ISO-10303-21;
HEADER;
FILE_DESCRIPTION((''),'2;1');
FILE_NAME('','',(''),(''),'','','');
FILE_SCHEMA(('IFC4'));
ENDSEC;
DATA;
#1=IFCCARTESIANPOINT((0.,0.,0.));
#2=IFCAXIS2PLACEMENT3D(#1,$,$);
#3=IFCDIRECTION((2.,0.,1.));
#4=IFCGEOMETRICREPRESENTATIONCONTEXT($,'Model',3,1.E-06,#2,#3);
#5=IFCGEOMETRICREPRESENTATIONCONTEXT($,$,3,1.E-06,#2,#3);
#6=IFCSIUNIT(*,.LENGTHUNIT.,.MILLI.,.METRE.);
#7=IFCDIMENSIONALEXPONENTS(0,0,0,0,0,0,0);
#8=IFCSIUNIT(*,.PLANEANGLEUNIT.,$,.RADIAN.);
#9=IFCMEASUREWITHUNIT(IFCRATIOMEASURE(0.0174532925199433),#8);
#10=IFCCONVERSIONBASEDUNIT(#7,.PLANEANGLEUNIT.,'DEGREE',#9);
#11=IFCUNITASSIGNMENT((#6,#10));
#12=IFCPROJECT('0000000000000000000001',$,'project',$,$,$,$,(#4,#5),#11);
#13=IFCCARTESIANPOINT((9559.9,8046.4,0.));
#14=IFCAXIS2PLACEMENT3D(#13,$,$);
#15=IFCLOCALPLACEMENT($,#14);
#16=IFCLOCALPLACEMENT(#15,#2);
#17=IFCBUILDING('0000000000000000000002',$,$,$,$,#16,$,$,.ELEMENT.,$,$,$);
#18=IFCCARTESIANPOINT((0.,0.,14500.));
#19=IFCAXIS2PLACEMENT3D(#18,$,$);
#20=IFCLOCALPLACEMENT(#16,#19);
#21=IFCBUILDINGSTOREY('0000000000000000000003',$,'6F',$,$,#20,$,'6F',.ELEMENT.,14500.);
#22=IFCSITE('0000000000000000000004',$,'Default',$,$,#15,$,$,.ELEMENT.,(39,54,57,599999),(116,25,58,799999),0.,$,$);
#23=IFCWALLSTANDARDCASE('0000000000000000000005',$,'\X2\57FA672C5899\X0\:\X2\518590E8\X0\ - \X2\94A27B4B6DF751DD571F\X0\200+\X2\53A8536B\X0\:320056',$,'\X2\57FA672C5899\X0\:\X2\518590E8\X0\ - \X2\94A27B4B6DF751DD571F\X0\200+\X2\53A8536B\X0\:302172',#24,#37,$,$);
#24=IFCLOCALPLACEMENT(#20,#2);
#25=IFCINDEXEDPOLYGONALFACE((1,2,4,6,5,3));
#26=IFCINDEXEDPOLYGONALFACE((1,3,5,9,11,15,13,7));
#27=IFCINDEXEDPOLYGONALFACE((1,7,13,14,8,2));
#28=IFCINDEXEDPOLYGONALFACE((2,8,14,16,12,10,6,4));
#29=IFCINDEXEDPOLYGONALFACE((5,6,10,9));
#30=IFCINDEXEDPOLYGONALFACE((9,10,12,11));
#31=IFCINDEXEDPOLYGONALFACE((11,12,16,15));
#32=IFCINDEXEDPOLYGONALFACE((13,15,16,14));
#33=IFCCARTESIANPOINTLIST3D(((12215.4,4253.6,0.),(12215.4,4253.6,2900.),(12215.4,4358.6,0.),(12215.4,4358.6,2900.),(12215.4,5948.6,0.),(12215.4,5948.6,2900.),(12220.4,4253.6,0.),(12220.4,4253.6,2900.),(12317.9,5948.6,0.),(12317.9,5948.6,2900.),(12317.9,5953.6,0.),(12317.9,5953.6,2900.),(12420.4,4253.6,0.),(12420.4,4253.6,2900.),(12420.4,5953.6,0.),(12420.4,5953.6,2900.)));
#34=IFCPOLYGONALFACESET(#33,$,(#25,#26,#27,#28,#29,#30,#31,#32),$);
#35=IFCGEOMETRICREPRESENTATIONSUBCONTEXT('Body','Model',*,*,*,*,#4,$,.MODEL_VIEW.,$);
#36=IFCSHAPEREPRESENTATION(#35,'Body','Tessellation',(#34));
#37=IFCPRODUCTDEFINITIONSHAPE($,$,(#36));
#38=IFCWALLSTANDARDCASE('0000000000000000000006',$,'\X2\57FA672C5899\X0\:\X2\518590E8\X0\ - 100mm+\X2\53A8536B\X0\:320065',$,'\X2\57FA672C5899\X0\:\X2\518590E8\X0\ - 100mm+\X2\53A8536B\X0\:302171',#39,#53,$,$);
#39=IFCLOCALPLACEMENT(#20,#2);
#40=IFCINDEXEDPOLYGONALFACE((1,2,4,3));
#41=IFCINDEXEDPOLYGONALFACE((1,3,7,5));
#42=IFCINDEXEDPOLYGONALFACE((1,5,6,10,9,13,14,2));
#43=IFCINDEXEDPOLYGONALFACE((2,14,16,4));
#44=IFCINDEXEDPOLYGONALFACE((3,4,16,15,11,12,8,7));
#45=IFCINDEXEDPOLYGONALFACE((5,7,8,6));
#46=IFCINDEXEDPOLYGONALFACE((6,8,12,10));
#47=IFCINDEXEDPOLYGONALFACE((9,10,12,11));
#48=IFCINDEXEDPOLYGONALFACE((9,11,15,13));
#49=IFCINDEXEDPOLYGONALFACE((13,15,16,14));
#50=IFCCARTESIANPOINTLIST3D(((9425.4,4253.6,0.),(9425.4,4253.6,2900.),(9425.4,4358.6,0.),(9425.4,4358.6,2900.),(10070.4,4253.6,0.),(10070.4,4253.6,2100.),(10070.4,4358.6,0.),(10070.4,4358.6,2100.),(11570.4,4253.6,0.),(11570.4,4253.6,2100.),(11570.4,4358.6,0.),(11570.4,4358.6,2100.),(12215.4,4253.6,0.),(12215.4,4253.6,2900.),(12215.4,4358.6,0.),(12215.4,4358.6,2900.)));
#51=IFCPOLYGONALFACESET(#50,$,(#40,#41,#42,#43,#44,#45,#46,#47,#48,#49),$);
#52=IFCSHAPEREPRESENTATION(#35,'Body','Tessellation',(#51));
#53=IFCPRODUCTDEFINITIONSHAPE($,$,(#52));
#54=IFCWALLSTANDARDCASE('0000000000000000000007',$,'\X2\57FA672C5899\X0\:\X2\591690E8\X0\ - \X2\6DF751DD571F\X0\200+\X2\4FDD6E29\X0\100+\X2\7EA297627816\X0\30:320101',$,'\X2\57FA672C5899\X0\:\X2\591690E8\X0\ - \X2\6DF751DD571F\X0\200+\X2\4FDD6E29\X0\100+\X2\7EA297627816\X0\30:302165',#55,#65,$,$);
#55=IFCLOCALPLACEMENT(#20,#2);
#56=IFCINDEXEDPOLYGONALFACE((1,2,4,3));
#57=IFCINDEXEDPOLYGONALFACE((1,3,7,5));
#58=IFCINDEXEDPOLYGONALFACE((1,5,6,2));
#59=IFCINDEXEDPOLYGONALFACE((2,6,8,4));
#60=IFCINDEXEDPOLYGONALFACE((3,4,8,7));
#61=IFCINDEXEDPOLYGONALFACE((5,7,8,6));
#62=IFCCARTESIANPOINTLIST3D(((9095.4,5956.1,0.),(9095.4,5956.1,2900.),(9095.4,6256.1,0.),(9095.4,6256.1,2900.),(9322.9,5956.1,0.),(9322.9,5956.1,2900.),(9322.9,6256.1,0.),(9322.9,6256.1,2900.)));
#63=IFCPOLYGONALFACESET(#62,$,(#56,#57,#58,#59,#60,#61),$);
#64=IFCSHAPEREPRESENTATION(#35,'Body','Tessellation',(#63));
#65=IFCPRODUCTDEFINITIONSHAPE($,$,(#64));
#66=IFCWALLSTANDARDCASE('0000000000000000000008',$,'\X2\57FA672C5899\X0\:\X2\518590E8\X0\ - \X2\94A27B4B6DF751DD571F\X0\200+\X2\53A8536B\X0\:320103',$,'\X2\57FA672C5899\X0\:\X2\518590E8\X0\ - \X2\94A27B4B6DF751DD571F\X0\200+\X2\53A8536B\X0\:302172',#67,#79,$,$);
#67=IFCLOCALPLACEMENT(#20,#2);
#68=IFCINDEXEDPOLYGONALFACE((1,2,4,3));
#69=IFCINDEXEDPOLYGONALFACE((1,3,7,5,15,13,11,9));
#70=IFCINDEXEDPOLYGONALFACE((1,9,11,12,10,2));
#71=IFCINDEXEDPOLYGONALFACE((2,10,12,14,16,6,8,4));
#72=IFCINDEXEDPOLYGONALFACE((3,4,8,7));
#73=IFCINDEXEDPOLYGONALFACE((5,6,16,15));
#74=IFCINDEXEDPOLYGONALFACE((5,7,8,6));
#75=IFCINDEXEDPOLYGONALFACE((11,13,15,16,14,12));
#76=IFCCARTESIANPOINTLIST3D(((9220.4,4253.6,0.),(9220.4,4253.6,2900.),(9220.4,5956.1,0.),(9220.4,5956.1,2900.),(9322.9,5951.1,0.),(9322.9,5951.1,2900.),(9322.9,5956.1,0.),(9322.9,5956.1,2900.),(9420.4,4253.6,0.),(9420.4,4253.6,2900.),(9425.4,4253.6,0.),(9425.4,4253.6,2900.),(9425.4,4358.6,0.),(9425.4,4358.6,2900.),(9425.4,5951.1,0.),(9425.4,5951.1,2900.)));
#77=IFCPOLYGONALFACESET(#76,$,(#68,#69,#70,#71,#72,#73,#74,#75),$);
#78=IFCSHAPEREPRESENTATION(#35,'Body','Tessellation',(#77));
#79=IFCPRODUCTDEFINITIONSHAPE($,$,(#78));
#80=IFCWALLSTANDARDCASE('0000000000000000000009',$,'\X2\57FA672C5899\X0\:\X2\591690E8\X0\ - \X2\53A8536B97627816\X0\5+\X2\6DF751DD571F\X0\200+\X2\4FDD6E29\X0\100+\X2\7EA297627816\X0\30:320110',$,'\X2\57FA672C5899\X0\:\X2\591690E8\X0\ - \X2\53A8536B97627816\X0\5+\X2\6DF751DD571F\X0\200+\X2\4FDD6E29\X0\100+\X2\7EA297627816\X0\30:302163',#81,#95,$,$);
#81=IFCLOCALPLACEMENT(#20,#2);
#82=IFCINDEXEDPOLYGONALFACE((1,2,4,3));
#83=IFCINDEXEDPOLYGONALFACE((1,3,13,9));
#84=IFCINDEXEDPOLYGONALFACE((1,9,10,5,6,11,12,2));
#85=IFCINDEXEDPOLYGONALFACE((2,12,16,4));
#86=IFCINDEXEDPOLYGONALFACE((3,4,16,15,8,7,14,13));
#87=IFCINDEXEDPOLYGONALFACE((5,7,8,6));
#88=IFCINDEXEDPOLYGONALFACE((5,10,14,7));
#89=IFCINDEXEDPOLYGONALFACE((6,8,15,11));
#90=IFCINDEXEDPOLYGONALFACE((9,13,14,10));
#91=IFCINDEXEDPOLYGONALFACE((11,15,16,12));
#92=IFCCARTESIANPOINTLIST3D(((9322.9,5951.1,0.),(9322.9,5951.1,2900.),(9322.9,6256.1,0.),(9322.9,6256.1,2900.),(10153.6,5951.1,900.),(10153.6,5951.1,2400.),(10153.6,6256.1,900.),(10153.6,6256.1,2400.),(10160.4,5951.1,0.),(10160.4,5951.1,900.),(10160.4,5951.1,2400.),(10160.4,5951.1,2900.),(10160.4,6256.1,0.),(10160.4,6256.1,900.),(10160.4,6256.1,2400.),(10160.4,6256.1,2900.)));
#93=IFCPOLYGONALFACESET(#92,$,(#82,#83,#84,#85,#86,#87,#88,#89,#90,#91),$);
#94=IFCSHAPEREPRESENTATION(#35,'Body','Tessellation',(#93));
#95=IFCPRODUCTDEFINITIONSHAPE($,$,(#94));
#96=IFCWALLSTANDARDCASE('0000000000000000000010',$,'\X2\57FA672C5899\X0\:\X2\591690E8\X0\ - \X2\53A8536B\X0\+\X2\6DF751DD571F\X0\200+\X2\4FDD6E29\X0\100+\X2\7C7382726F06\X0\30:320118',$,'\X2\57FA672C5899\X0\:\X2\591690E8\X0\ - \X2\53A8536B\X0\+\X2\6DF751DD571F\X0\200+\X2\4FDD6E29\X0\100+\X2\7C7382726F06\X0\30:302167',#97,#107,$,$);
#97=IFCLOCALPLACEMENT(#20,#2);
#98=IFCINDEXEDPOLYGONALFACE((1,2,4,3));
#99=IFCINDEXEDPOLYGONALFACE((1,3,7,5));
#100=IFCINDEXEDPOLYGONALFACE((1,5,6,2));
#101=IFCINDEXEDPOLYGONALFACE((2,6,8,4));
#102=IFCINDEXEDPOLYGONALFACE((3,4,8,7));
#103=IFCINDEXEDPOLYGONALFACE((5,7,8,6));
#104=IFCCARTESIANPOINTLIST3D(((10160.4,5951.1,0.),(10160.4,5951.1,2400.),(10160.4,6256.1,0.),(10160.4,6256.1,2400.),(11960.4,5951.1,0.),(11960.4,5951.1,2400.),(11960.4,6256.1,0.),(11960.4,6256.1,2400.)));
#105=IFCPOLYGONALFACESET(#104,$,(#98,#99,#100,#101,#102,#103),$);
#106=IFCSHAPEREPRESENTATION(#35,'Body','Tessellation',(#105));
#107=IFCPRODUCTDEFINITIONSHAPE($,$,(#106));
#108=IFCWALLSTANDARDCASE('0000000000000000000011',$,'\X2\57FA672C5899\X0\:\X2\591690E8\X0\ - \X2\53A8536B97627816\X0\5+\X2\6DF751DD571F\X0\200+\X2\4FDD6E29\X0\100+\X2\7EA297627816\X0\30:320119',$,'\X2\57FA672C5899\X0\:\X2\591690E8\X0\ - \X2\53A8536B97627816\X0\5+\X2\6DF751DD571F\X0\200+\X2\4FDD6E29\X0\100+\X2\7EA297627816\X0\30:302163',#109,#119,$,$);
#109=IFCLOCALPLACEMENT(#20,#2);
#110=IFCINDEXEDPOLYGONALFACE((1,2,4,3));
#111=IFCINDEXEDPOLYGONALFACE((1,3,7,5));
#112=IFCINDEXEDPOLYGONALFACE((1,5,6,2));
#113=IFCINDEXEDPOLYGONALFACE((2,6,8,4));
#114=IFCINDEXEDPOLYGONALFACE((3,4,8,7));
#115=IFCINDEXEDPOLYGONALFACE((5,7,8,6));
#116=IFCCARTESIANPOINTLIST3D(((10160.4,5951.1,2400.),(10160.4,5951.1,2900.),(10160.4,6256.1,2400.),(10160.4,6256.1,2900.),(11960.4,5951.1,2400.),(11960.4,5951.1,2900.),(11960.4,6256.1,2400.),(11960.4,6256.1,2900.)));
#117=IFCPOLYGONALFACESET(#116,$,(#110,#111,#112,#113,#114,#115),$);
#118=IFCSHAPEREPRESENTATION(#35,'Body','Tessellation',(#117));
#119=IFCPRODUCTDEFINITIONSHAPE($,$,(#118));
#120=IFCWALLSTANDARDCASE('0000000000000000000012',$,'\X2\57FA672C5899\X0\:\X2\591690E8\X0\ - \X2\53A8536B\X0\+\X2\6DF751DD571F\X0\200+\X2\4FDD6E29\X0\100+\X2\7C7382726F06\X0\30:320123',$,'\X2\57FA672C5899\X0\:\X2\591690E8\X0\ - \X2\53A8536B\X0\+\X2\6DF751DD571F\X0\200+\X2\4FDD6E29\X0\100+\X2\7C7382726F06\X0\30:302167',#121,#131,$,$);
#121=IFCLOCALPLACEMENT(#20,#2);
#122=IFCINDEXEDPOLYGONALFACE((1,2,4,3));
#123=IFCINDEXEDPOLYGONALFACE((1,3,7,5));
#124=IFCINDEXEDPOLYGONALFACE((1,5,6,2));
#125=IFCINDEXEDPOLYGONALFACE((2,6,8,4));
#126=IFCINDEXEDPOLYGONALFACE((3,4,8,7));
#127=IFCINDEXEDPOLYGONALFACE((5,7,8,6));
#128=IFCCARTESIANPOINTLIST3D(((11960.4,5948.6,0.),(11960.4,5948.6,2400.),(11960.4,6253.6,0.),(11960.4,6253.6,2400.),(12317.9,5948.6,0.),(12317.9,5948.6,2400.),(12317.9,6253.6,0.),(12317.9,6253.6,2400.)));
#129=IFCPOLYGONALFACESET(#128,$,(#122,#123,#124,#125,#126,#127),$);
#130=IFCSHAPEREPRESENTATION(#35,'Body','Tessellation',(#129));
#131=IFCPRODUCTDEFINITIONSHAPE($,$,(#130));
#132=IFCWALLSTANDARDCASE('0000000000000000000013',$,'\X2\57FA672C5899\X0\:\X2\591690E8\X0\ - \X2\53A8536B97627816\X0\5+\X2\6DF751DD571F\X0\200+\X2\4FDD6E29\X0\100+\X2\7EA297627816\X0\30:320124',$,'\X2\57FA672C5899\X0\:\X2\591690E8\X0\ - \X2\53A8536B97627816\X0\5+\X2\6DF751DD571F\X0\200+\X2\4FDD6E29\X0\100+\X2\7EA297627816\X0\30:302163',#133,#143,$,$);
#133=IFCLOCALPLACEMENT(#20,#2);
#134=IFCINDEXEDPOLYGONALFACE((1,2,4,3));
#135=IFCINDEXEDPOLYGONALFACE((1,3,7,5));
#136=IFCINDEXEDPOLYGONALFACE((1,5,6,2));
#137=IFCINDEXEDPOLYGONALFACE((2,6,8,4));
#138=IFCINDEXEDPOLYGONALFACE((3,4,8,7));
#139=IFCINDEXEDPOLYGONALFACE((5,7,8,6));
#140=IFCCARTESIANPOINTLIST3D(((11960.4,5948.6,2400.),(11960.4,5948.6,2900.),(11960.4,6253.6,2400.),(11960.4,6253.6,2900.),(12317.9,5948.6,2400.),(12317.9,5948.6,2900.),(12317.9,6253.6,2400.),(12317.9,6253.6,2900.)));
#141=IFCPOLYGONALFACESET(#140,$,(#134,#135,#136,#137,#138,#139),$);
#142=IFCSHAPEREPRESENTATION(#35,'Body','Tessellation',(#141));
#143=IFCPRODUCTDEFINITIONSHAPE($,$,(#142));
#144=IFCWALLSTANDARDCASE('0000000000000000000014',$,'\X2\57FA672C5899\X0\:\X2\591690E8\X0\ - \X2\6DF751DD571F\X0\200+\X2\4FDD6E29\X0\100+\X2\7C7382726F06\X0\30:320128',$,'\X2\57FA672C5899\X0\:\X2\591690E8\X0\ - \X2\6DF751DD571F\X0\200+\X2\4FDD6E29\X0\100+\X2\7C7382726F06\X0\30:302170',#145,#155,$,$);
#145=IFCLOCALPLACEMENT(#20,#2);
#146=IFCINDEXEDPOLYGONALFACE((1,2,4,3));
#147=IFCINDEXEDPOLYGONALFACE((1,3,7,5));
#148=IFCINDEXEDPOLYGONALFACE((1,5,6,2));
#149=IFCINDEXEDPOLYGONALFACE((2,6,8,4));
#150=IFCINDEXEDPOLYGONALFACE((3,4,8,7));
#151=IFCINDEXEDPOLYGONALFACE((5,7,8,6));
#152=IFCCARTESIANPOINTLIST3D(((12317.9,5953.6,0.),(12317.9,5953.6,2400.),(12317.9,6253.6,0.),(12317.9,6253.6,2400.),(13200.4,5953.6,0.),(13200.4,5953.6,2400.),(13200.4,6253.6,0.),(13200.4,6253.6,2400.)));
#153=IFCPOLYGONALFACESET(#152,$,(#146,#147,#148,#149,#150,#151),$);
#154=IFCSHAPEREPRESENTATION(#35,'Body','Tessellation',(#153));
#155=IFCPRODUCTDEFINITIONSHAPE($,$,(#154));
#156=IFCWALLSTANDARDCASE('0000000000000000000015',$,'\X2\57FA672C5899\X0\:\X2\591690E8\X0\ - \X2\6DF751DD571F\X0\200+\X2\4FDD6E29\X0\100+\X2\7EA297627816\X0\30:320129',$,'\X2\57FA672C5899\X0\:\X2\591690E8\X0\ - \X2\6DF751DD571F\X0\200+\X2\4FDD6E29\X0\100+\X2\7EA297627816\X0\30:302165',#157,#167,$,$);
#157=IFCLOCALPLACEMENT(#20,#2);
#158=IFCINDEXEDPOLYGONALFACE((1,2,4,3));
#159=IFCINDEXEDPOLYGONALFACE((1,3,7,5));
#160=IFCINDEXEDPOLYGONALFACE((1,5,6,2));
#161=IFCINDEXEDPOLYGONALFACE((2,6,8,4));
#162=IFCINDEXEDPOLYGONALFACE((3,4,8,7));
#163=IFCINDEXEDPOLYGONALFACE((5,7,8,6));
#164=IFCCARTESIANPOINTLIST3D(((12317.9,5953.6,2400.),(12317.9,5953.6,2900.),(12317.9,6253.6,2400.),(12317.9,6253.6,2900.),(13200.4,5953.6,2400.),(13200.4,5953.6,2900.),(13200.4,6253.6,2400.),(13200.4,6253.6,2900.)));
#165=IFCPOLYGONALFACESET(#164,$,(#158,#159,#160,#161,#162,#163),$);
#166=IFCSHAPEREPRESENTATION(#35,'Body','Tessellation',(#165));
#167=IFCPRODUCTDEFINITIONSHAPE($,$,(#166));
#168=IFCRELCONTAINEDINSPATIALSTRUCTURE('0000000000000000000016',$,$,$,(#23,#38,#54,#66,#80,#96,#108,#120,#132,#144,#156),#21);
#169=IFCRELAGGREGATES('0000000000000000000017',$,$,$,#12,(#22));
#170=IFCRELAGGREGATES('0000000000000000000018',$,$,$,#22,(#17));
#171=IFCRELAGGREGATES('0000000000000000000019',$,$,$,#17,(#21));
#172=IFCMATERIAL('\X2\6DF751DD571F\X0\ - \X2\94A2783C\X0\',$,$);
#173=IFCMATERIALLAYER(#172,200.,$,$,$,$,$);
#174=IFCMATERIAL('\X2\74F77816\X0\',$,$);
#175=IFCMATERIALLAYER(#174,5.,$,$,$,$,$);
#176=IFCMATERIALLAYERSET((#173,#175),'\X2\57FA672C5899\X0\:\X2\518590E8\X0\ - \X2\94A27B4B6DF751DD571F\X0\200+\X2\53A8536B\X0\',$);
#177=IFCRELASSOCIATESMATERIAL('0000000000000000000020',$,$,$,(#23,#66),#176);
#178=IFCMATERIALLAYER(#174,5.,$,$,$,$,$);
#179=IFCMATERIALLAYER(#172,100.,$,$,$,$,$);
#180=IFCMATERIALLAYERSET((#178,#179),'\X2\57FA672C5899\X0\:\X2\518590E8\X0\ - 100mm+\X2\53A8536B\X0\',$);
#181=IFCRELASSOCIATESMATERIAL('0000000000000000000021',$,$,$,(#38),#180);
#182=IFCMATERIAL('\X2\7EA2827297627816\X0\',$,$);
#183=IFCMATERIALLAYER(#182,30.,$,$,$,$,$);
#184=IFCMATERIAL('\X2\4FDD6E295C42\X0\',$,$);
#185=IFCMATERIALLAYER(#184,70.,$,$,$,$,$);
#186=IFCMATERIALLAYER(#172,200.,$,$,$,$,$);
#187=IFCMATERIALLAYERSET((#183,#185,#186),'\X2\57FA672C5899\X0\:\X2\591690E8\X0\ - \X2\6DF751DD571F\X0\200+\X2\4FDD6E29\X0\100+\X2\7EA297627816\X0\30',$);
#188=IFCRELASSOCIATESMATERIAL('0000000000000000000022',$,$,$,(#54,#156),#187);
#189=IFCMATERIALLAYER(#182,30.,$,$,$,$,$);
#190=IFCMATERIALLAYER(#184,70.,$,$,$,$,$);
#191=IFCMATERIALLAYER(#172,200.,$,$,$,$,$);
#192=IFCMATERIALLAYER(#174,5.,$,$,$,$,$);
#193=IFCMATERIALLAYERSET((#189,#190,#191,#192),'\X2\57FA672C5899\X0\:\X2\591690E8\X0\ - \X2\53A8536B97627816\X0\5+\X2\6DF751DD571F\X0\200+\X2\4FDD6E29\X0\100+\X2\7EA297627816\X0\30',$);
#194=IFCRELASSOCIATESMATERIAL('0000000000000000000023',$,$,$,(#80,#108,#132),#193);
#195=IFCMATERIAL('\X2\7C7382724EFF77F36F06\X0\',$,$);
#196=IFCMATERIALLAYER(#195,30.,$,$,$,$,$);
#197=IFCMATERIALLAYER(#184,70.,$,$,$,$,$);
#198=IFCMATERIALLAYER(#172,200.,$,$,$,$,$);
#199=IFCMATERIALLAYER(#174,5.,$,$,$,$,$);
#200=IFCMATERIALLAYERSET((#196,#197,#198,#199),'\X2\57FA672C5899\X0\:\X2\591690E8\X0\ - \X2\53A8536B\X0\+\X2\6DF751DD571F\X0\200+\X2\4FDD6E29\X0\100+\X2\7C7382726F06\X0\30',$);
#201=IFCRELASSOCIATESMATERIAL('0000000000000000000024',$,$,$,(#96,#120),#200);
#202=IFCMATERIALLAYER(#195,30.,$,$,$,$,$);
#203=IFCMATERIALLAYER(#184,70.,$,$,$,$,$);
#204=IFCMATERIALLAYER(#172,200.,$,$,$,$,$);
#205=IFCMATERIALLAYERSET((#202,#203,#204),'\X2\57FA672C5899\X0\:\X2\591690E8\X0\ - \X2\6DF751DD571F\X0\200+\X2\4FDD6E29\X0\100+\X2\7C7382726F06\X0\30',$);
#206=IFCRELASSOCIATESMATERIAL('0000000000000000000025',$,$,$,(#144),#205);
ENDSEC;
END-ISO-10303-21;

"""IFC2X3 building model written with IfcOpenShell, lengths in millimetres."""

from ifc_helpers import new_model, entity, si_unit, converted_unit, direction, frame, frame_2d, origin, place, context, subcontext, project, spatial, polyline, rectangle, outline, extrude, material, layer, layer_set, layer_usage, element, save


model = new_model("IFC2X3")

# Units and contexts
model_context = context("Model", 3, precision=1e-06, world=origin(), true_north=direction((2.0, 0.0, 1.0)))
context_of_model = context(None, 3, precision=1e-06, world=origin(), true_north=direction((2.0, 0.0, 1.0)))
body_context = subcontext(model_context, "Body", "Model", "MODEL_VIEW")
ifc_project = project(units=[si_unit("LENGTHUNIT", "METRE", prefix="MILLI"), converted_unit("PLANEANGLEUNIT", "DEGREE", entity("IfcRatioMeasure", 0.0174532925199433), si_unit("PLANEANGLEUNIT", "RADIAN"), dimensions=[0, 0, 0, 0, 0, 0, 0])], contexts=[model_context, context_of_model])

# Site, building, storey
site_placement = place(None, frame((9559.9, 8046.4, 0.0)))
site = spatial("IfcSite", under=ifc_project, at=site_placement, Name="Default", CompositionType="ELEMENT", RefLatitude=(39, 54, 57, 599999), RefLongitude=(116, 25, 58, 799999), RefElevation=0.0)
building_placement = place(site_placement, origin())
building = spatial("IfcBuilding", under=site, at=building_placement, CompositionType="ELEMENT")
storey_placement = place(building_placement, frame((0.0, 0.0, 14500.0)))
storey = spatial("IfcBuildingStorey", under=building, at=storey_placement, Name="6F", LongName="6F", CompositionType="ELEMENT", Elevation=14500.0)

# Shared definitions
ifc_material_1 = material(Name="红色面砖")
ifc_layer_1 = layer(ifc_material_1, 30.0)
ifc_material_2 = material(Name="保温层")
ifc_layer_2 = layer(ifc_material_2, 70.0)
ifc_material_3 = material(Name="混凝土 - 钢砼")
ifc_layer_3 = layer(ifc_material_3, 200.0)
ifc_layer_set_1 = layer_set([ifc_layer_1, ifc_layer_2, ifc_layer_3], Name="基本墙:外部 - 混凝土200+保温100+红面砖30")

# Wall
ifc_layer_4 = layer(ifc_material_3, 200.0)
ifc_material_4 = material(Name="瓷砖")
ifc_layer_5 = layer(ifc_material_4, 5.0)
ifc_layer_set_2 = layer_set([ifc_layer_4, ifc_layer_5], Name="基本墙:内部 - 钢筋混凝土200+厨卫")
ifc_layer_usage_1 = layer_usage(ifc_layer_set_2, "AXIS2", "NEGATIVE", 102.5)
wall_1_placement = place(storey_placement, frame((12317.9, 5953.6, 0.0), z_axis=(0.0, 0.0, 1.0), x_axis=(0.0, -1.0, 0.0)))
element("IfcWallStandardCase", 1, at=wall_1_placement, inside=storey, material=ifc_layer_usage_1, Name="基本墙:内部 - 钢筋混凝土200+厨卫:320056", ObjectType="基本墙:内部 - 钢筋混凝土200+厨卫:302172", context=body_context, shape_type="SweptSolid", body=[
    extrude(outline(polyline([(1700.0, -102.5), (1700.0, -97.5), (1700.0, 102.5), (0.0, 102.5), (0.0, 0.0), (5.0, 0.0), (5.0, -102.5), (1595.0, -102.5), (1700.0, -102.5)])), origin(), (0.0, 0.0, 1.0), 2900.0),
])

# Wall, opening
ifc_layer_6 = layer(ifc_material_4, 5.0)
ifc_layer_7 = layer(ifc_material_3, 100.0)
ifc_layer_set_3 = layer_set([ifc_layer_6, ifc_layer_7], Name="基本墙:内部 - 100mm+厨卫")
ifc_layer_usage_2 = layer_usage(ifc_layer_set_3, "AXIS2", "POSITIVE", -52.5)
wall_2_placement = place(storey_placement, frame((12215.4, 4306.1, 0.0), z_axis=(0.0, 0.0, 1.0), x_axis=(-1.0, 0.0, 0.0)))
wall_2 = element("IfcWallStandardCase", 2, at=wall_2_placement, inside=storey, material=ifc_layer_usage_2, Name="基本墙:内部 - 100mm+厨卫:320065", ObjectType="基本墙:内部 - 100mm+厨卫:302171", context=body_context, shape_type="SweptSolid", body=[
    extrude(rectangle(XDim=2790.0, YDim=105.0, at=frame_2d((1395.0, 0.0), x_axis=(-1.0, 0.0))), origin(), (0.0, 0.0, 1.0), 2900.0),
])
opening_1_placement = place(wall_2_placement, frame((645.0, -52.5, 0.0)))
element("IfcOpeningElement", 3, at=opening_1_placement, cuts=wall_2, ObjectType="Opening", context=body_context, shape_type="SweptSolid", body=[
    extrude(rectangle(XDim=2100.0, YDim=1500.0, at=frame_2d((1050.0, 750.0), x_axis=(1.0, 0.0))), frame((0.0, 0.0, 0.0), z_axis=(0.0, 1.0, 0.0), x_axis=(0.0, 0.0, 1.0)), (0.0, 0.0, 1.0), 105.0),
])

# Walls
ifc_layer_usage_3 = layer_usage(ifc_layer_set_1, "AXIS2", "POSITIVE", -150.0)
wall_3_placement = place(storey_placement, frame((9322.9, 6106.1, 0.0), z_axis=(0.0, 0.0, 1.0), x_axis=(-1.0, 0.0, 0.0)))
element("IfcWallStandardCase", 4, at=wall_3_placement, inside=storey, material=ifc_layer_usage_3, Name="基本墙:外部 - 混凝土200+保温100+红面砖30:320101", ObjectType="基本墙:外部 - 混凝土200+保温100+红面砖30:302165", context=body_context, shape_type="SweptSolid", body=[
    extrude(rectangle(XDim=227.5, YDim=300.0, at=frame_2d((113.8, 0.0), x_axis=(-1.0, 0.0))), origin(), (0.0, 0.0, 1.0), 2900.0),
])
ifc_layer_usage_4 = layer_usage(ifc_layer_set_2, "AXIS2", "POSITIVE", -102.5)
wall_4_placement = place(storey_placement, frame((9322.9, 5956.1, 0.0), z_axis=(0.0, 0.0, 1.0), x_axis=(0.0, -1.0, 0.0)))
element("IfcWallStandardCase", 5, at=wall_4_placement, inside=storey, material=ifc_layer_usage_4, Name="基本墙:内部 - 钢筋混凝土200+厨卫:320103", ObjectType="基本墙:内部 - 钢筋混凝土200+厨卫:302172", context=body_context, shape_type="SweptSolid", body=[
    extrude(outline(polyline([(1702.5, -102.5), (1702.5, 97.5), (1702.5, 102.5), (1597.5, 102.5), (5.0, 102.5), (5.0, 0.0), (0.0, 0.0), (0.0, -102.5), (1702.5, -102.5)])), origin(), (0.0, 0.0, 1.0), 2900.0),
])

# Wall, opening
ifc_layer_8 = layer(ifc_material_1, 30.0)
ifc_layer_9 = layer(ifc_material_2, 70.0)
ifc_layer_10 = layer(ifc_material_3, 200.0)
ifc_layer_11 = layer(ifc_material_4, 5.0)
ifc_layer_set_4 = layer_set([ifc_layer_8, ifc_layer_9, ifc_layer_10, ifc_layer_11], Name="基本墙:外部 - 厨卫面砖5+混凝土200+保温100+红面砖30")
ifc_layer_usage_5 = layer_usage(ifc_layer_set_4, "AXIS2", "POSITIVE", -152.5)
wall_5_placement = place(storey_placement, frame((10160.4, 6103.6, 0.0), z_axis=(0.0, 0.0, 1.0), x_axis=(-1.0, 0.0, 0.0)))
wall_5 = element("IfcWallStandardCase", 6, at=wall_5_placement, inside=storey, material=ifc_layer_usage_5, Name="基本墙:外部 - 厨卫面砖5+混凝土200+保温100+红面砖30:320110", ObjectType="基本墙:外部 - 厨卫面砖5+混凝土200+保温100+红面砖30:302163", context=body_context, shape_type="SweptSolid", body=[
    extrude(rectangle(XDim=837.5, YDim=305.0, at=frame_2d((418.8, 0.0), x_axis=(-1.0, 0.0))), origin(), (0.0, 0.0, 1.0), 2900.0),
])
opening_2_placement = place(wall_5_placement, frame((6.7, 152.5, 900.0)))
element("IfcOpeningElement", 7, at=opening_2_placement, cuts=wall_5, ObjectType="Opening", context=body_context, shape_type="SweptSolid", body=[
    extrude(rectangle(XDim=1500.0, YDim=1800.0, at=frame_2d((750.0, 900.0), x_axis=(1.0, 0.0))), frame((0.0, 0.0, 0.0), z_axis=(0.0, -1.0, 0.0), x_axis=(0.0, 0.0, 1.0)), (0.0, 0.0, 1.0), 305.0),
])

# Walls
ifc_material_5 = material(Name="米色仿石漆")
ifc_layer_12 = layer(ifc_material_5, 30.0)
ifc_layer_13 = layer(ifc_material_2, 70.0)
ifc_layer_14 = layer(ifc_material_3, 200.0)
ifc_layer_15 = layer(ifc_material_4, 5.0)
ifc_layer_set_5 = layer_set([ifc_layer_12, ifc_layer_13, ifc_layer_14, ifc_layer_15], Name="基本墙:外部 - 厨卫+混凝土200+保温100+米色漆30")
ifc_layer_usage_6 = layer_usage(ifc_layer_set_5, "AXIS2", "POSITIVE", -152.5)
wall_6_placement = place(storey_placement, frame((11960.4, 6103.6, 0.0), z_axis=(0.0, 0.0, 1.0), x_axis=(-1.0, 0.0, 0.0)))
element("IfcWallStandardCase", 8, at=wall_6_placement, inside=storey, material=ifc_layer_usage_6, Name="基本墙:外部 - 厨卫+混凝土200+保温100+米色漆30:320118", ObjectType="基本墙:外部 - 厨卫+混凝土200+保温100+米色漆30:302167", context=body_context, shape_type="SweptSolid", body=[
    extrude(rectangle(XDim=1800.0, YDim=305.0, at=frame_2d((900.0, 0.0), x_axis=(-1.0, 0.0))), origin(), (0.0, 0.0, 1.0), 2400.0),
])
ifc_layer_usage_7 = layer_usage(ifc_layer_set_4, "AXIS2", "POSITIVE", -152.5)
wall_7_placement = place(storey_placement, frame((11960.4, 6103.6, 2400.0), z_axis=(0.0, 0.0, 1.0), x_axis=(-1.0, 0.0, 0.0)))
element("IfcWallStandardCase", 9, at=wall_7_placement, inside=storey, material=ifc_layer_usage_7, Name="基本墙:外部 - 厨卫面砖5+混凝土200+保温100+红面砖30:320119", ObjectType="基本墙:外部 - 厨卫面砖5+混凝土200+保温100+红面砖30:302163", context=body_context, shape_type="SweptSolid", body=[
    extrude(rectangle(XDim=1800.0, YDim=305.0, at=frame_2d((900.0, 0.0), x_axis=(-1.0, 0.0))), origin(), (0.0, 0.0, 1.0), 500.0),
])
ifc_layer_usage_8 = layer_usage(ifc_layer_set_5, "AXIS2", "POSITIVE", -152.5)
wall_8_placement = place(storey_placement, frame((12317.9, 6101.1, 0.0), z_axis=(0.0, 0.0, 1.0), x_axis=(-1.0, 0.0, 0.0)))
element("IfcWallStandardCase", 10, at=wall_8_placement, inside=storey, material=ifc_layer_usage_8, Name="基本墙:外部 - 厨卫+混凝土200+保温100+米色漆30:320123", ObjectType="基本墙:外部 - 厨卫+混凝土200+保温100+米色漆30:302167", context=body_context, shape_type="SweptSolid", body=[
    extrude(rectangle(XDim=357.5, YDim=305.0, at=frame_2d((178.8, 0.0), x_axis=(-1.0, 0.0))), origin(), (0.0, 0.0, 1.0), 2400.0),
])
ifc_layer_usage_9 = layer_usage(ifc_layer_set_4, "AXIS2", "POSITIVE", -152.5)
wall_9_placement = place(storey_placement, frame((12317.9, 6101.1, 2400.0), z_axis=(0.0, 0.0, 1.0), x_axis=(-1.0, 0.0, 0.0)))
element("IfcWallStandardCase", 11, at=wall_9_placement, inside=storey, material=ifc_layer_usage_9, Name="基本墙:外部 - 厨卫面砖5+混凝土200+保温100+红面砖30:320124", ObjectType="基本墙:外部 - 厨卫面砖5+混凝土200+保温100+红面砖30:302163", context=body_context, shape_type="SweptSolid", body=[
    extrude(rectangle(XDim=357.5, YDim=305.0, at=frame_2d((178.8, 0.0), x_axis=(-1.0, 0.0))), origin(), (0.0, 0.0, 1.0), 500.0),
])
ifc_layer_16 = layer(ifc_material_5, 30.0)
ifc_layer_17 = layer(ifc_material_2, 70.0)
ifc_layer_18 = layer(ifc_material_3, 200.0)
ifc_layer_set_6 = layer_set([ifc_layer_16, ifc_layer_17, ifc_layer_18], Name="基本墙:外部 - 混凝土200+保温100+米色漆30")
ifc_layer_usage_10 = layer_usage(ifc_layer_set_6, "AXIS2", "POSITIVE", -150.0)
wall_10_placement = place(storey_placement, frame((13200.4, 6103.6, 0.0), z_axis=(0.0, 0.0, 1.0), x_axis=(-1.0, 0.0, 0.0)))
element("IfcWallStandardCase", 12, at=wall_10_placement, inside=storey, material=ifc_layer_usage_10, Name="基本墙:外部 - 混凝土200+保温100+米色漆30:320128", ObjectType="基本墙:外部 - 混凝土200+保温100+米色漆30:302170", context=body_context, shape_type="SweptSolid", body=[
    extrude(rectangle(XDim=882.5, YDim=300.0, at=frame_2d((441.2, 0.0), x_axis=(-1.0, 0.0))), origin(), (0.0, 0.0, 1.0), 2400.0),
])
ifc_layer_usage_11 = layer_usage(ifc_layer_set_1, "AXIS2", "POSITIVE", -150.0)
wall_11_placement = place(storey_placement, frame((13200.4, 6103.6, 2400.0), z_axis=(0.0, 0.0, 1.0), x_axis=(-1.0, 0.0, 0.0)))
element("IfcWallStandardCase", 13, at=wall_11_placement, inside=storey, material=ifc_layer_usage_11, Name="基本墙:外部 - 混凝土200+保温100+红面砖30:320129", ObjectType="基本墙:外部 - 混凝土200+保温100+红面砖30:302165", context=body_context, shape_type="SweptSolid", body=[
    extrude(rectangle(XDim=882.5, YDim=300.0, at=frame_2d((441.2, 0.0), x_axis=(-1.0, 0.0))), origin(), (0.0, 0.0, 1.0), 500.0),
])

save(model, "model.ifc")
